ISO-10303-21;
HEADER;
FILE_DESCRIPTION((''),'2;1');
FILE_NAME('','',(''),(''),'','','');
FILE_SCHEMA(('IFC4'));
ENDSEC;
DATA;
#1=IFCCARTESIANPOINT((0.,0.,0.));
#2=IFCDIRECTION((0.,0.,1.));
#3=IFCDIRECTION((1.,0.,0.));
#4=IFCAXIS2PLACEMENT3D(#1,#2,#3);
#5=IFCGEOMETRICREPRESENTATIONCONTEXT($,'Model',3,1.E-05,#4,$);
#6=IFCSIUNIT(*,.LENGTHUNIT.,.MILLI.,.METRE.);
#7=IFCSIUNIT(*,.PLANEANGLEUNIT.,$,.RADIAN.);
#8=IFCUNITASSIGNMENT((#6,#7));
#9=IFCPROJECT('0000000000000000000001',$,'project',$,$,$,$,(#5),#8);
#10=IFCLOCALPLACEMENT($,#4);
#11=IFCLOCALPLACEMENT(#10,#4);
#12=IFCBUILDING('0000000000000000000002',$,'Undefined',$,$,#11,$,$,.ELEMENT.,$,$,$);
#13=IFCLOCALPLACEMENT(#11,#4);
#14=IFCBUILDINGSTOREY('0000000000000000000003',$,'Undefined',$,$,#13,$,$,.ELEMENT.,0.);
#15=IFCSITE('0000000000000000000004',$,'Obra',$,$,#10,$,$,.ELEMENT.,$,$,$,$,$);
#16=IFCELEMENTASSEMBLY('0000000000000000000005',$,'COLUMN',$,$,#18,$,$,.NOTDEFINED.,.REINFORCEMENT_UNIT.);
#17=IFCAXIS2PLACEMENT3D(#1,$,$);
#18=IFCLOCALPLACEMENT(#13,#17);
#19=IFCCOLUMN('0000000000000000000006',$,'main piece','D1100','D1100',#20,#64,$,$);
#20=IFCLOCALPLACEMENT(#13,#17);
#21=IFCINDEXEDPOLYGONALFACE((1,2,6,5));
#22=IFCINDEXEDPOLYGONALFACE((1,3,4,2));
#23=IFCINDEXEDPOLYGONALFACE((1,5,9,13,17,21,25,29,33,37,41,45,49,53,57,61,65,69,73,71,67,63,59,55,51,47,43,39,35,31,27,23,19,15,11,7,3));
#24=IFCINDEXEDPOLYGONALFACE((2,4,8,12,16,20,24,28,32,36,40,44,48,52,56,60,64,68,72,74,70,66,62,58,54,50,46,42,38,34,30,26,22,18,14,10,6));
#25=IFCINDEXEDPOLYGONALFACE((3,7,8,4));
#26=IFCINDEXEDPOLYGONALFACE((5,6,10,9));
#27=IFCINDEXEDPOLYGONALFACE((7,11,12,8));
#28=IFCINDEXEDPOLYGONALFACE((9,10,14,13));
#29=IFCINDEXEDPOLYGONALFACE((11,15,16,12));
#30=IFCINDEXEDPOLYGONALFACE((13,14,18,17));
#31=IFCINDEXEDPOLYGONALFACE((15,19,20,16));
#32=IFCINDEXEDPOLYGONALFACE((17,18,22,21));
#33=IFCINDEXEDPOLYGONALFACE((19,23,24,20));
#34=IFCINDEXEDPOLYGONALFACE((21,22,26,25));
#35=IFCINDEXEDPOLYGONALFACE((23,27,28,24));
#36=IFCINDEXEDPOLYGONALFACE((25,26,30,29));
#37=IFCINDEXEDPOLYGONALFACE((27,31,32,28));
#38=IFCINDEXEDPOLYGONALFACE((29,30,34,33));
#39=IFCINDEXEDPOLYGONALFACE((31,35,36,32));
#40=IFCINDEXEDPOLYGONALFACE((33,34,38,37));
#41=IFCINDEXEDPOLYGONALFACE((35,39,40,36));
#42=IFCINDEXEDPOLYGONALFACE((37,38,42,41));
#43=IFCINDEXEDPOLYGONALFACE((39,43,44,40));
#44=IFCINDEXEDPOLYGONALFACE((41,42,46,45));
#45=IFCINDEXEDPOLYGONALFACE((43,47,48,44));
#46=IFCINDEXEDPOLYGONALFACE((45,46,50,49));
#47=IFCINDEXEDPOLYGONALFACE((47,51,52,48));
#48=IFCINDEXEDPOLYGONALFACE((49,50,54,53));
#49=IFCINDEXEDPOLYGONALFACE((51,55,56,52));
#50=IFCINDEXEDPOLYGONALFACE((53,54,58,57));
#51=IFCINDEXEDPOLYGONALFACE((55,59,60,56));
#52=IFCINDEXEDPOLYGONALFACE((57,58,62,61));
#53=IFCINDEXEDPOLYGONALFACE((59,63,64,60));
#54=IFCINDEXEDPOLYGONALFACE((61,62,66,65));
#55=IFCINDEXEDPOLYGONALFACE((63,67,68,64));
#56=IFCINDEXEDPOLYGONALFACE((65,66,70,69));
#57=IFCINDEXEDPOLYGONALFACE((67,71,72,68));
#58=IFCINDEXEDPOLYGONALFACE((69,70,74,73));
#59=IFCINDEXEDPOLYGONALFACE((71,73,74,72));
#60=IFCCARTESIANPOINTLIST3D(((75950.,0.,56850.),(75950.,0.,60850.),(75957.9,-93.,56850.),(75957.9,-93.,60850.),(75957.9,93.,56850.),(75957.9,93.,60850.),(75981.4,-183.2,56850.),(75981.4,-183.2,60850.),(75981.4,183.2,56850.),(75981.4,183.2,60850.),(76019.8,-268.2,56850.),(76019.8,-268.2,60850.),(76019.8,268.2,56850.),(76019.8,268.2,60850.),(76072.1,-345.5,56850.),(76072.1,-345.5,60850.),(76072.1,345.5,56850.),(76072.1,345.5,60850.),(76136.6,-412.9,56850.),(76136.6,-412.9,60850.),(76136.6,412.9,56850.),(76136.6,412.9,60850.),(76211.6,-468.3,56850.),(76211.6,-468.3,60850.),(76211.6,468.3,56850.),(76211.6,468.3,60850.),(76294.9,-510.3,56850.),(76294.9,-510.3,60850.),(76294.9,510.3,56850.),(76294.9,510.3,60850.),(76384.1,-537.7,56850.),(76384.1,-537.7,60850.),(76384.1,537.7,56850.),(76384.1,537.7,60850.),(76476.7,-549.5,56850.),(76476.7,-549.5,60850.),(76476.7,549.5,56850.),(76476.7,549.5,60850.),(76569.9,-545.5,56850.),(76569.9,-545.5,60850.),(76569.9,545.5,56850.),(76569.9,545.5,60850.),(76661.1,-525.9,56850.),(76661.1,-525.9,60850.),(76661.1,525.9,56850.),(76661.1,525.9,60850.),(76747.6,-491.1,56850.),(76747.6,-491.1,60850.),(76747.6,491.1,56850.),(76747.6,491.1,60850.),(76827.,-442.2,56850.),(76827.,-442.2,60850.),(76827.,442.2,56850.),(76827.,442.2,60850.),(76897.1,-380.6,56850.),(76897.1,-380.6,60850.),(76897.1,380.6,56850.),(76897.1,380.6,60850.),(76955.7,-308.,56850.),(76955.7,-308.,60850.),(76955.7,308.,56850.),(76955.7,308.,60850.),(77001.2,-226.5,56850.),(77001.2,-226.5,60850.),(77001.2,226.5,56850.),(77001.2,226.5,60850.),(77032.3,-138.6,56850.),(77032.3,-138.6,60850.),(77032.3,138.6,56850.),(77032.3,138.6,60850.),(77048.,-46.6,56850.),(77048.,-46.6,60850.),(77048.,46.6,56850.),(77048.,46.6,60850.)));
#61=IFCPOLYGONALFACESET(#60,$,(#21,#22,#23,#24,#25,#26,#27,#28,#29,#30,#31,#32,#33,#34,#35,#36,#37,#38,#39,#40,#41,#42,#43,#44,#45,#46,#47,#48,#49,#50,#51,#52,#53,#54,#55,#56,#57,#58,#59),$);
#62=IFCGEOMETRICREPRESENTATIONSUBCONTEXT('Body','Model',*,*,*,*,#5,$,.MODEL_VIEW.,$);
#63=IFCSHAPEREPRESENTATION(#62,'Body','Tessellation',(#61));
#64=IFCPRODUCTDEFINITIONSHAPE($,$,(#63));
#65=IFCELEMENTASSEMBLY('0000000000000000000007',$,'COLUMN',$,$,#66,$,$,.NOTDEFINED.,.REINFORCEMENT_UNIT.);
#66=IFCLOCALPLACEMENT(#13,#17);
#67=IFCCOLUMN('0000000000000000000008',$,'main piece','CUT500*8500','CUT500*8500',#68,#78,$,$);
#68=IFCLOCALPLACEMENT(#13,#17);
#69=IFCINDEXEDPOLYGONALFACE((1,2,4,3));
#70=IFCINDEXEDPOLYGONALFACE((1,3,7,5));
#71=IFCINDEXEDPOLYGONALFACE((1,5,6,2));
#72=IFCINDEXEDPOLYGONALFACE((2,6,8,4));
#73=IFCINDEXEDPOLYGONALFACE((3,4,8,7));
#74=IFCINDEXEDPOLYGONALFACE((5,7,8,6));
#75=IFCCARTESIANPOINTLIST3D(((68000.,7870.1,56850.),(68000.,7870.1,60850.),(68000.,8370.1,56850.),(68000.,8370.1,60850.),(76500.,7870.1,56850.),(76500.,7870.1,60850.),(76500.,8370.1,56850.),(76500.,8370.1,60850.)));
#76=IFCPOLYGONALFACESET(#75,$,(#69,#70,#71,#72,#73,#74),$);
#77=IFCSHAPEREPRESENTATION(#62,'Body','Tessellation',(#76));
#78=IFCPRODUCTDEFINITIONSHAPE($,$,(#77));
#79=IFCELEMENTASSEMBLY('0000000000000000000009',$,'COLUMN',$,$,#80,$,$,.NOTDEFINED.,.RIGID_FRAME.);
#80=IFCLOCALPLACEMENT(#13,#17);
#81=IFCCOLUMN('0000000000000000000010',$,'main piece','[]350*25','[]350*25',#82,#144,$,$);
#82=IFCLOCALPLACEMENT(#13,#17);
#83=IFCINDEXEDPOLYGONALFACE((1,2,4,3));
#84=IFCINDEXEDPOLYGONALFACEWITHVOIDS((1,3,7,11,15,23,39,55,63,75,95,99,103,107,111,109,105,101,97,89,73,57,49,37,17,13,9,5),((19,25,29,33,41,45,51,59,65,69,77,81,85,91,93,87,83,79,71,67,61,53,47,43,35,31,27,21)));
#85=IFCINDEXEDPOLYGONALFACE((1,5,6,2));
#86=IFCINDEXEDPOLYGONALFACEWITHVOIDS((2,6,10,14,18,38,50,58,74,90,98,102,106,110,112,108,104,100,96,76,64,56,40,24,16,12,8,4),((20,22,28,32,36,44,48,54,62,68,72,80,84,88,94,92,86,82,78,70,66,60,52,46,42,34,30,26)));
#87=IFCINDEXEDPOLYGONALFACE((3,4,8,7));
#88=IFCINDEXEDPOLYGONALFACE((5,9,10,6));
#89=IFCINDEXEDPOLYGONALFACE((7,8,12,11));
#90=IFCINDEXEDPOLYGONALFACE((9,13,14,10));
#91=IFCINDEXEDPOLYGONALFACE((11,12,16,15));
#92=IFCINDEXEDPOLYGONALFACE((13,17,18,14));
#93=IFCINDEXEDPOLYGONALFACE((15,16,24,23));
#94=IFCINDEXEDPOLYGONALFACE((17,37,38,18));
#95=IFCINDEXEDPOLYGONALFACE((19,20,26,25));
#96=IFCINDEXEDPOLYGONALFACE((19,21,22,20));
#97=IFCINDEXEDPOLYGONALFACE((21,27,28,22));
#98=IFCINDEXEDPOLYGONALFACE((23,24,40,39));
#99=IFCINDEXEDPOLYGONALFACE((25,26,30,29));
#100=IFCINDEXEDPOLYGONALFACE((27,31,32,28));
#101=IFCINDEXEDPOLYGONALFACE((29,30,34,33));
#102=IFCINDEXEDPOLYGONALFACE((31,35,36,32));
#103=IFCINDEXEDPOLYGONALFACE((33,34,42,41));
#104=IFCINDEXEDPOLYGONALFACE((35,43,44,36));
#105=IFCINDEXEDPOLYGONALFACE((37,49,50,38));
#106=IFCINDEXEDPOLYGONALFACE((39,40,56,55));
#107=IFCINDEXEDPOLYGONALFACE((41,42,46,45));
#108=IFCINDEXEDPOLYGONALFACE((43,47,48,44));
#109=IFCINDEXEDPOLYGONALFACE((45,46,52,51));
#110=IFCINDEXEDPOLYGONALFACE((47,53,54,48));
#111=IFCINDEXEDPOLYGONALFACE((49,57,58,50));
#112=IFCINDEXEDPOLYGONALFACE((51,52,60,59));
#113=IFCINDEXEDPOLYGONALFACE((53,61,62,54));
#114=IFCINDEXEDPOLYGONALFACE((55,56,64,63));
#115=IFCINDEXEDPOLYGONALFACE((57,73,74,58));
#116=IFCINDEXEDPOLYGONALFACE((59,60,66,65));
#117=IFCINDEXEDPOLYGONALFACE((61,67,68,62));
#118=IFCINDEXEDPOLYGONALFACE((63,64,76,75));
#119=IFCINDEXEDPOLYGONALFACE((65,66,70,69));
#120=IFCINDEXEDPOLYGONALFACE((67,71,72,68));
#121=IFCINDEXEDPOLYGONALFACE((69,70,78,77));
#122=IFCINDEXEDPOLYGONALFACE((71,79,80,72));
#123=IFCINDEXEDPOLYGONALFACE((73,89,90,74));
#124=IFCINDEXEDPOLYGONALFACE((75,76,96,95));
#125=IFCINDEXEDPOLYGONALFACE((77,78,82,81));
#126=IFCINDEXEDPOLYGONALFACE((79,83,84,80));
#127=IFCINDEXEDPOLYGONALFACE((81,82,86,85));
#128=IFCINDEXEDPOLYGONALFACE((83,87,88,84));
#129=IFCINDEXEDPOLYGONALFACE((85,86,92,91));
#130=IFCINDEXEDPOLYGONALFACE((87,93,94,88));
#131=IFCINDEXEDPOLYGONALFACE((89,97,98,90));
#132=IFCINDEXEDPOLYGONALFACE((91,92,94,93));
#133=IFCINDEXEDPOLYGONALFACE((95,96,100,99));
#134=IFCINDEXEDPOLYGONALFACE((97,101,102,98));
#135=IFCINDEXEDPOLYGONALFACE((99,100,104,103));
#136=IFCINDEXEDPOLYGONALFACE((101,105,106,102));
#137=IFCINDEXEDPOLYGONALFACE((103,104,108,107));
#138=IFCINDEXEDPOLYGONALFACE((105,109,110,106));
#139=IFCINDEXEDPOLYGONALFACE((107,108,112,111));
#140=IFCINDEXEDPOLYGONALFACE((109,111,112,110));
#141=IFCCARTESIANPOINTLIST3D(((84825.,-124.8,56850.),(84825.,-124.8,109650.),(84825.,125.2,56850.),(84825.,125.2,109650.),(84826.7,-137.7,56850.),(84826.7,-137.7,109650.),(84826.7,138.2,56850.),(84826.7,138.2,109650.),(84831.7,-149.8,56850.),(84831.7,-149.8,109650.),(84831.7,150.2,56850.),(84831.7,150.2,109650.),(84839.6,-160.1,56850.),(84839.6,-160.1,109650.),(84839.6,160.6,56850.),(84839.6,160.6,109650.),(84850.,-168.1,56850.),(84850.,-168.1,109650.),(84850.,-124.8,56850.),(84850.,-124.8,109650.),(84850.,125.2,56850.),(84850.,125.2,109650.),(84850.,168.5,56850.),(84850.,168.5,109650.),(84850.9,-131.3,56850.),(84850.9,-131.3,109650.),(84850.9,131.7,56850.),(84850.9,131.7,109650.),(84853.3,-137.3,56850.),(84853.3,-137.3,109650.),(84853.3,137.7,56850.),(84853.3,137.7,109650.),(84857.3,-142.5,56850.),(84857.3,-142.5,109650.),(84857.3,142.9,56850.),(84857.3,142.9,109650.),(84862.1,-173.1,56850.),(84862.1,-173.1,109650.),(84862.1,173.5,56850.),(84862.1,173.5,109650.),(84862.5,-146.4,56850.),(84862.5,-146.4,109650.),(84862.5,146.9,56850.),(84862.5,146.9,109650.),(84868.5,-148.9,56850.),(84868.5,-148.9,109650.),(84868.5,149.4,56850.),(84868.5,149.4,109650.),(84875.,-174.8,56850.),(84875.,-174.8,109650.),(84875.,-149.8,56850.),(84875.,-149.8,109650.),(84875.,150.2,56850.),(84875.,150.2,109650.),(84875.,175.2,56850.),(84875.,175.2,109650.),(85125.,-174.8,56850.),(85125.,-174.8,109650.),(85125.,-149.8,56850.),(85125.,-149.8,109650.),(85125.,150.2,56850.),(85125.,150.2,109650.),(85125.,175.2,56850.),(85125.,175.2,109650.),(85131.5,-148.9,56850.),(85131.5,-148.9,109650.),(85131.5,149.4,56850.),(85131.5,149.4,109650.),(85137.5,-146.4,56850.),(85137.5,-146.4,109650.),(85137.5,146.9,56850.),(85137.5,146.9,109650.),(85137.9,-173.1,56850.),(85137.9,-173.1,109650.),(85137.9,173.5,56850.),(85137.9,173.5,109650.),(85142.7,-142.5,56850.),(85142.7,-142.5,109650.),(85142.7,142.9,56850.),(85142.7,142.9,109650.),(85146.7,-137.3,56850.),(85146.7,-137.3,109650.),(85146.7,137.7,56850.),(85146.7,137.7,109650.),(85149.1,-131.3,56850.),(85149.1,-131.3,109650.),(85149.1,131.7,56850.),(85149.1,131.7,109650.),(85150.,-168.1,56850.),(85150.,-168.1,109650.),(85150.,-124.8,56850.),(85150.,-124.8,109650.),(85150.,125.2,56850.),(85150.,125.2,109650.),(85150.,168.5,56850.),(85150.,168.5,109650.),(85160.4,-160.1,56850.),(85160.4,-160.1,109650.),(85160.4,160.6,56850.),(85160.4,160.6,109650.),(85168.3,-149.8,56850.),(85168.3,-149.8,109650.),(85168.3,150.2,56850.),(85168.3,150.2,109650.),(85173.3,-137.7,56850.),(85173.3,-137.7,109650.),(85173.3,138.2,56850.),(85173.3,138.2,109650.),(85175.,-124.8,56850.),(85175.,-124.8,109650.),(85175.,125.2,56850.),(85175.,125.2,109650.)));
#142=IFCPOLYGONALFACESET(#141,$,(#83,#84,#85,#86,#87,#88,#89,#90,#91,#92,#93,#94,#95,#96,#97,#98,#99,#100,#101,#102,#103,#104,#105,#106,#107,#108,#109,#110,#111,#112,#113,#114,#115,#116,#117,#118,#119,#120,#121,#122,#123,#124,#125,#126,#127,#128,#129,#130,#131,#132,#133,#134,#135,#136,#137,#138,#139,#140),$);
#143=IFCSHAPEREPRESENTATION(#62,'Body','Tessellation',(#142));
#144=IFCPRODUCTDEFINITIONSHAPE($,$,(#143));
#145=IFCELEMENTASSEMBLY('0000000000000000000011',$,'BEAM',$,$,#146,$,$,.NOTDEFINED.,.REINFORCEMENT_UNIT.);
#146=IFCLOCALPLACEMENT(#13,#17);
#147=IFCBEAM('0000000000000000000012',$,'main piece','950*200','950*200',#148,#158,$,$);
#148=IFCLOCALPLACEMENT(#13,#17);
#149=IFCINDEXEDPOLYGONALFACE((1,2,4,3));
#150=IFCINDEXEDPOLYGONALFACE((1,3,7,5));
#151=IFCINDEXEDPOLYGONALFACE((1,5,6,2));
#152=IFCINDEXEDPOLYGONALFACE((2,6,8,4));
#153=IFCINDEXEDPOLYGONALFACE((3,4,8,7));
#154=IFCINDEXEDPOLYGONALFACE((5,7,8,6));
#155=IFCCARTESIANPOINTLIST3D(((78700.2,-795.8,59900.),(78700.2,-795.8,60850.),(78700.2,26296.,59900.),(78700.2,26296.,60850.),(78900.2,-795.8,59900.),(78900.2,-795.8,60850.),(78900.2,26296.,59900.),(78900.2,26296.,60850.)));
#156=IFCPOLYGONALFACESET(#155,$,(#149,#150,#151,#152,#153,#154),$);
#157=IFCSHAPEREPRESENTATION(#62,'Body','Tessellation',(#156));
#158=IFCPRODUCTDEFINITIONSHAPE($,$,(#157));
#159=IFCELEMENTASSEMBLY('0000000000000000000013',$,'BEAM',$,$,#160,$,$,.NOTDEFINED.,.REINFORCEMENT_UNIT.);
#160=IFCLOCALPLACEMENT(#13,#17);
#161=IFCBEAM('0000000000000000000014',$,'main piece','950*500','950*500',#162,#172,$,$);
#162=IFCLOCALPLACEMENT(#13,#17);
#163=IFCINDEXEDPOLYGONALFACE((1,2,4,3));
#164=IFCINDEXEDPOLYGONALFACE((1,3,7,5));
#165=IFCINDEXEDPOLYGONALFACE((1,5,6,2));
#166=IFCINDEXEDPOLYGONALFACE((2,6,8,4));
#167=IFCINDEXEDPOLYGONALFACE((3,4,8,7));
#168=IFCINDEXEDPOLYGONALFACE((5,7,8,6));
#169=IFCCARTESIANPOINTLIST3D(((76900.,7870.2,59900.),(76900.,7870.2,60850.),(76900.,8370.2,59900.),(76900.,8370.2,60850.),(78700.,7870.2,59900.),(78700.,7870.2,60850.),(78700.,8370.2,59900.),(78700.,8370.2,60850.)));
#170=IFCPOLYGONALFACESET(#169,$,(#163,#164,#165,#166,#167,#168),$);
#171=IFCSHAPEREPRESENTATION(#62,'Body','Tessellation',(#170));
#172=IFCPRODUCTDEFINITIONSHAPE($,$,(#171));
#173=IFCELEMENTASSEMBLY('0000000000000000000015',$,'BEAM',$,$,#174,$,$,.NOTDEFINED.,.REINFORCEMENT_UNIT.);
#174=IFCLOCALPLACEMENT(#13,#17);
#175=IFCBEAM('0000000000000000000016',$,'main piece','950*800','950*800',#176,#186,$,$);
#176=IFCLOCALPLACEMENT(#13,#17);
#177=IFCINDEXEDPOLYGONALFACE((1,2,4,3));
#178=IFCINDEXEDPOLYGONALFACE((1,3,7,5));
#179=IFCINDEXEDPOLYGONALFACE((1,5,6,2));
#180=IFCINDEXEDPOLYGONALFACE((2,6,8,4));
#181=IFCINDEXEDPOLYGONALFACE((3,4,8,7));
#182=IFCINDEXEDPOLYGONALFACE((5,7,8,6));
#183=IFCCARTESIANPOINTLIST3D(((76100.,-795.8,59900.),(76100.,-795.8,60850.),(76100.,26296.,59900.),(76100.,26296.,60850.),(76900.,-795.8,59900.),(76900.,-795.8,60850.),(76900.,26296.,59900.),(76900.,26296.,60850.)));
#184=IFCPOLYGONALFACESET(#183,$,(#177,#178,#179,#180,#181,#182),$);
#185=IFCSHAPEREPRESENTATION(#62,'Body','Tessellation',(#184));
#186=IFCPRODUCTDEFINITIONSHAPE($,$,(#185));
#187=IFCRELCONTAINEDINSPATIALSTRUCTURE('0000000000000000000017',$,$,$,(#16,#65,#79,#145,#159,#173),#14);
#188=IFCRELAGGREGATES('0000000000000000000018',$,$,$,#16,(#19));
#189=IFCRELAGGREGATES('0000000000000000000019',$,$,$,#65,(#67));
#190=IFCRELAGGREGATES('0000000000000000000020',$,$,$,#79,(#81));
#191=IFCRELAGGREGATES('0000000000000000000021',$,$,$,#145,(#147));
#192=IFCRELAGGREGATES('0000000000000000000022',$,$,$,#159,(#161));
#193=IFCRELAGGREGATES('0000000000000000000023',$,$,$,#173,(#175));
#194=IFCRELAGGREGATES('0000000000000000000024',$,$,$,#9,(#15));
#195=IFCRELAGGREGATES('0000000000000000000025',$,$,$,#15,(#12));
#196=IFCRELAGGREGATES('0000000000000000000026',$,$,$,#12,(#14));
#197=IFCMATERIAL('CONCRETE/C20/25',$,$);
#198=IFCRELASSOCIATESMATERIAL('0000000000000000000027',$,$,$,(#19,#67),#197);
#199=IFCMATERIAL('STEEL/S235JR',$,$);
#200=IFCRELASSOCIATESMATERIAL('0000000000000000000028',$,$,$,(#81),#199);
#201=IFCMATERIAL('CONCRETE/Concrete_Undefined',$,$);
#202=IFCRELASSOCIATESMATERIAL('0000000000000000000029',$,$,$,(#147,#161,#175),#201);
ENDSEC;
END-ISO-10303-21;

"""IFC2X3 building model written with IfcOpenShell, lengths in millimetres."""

from ifc_helpers import new_model, si_unit, frame, origin_with_axes, origin_2d_with_axis, place, context, subcontext, project, spatial, rectangle, hollow_rectangle, circle, extrude, material, element, aggregate, save


model = new_model("IFC2X3")

# Units and contexts
model_context = context("Model", 3, precision=1e-05, world=origin_with_axes())
body_context = subcontext(model_context, "Body", "Model", "MODEL_VIEW")
ifc_project = project(units=[si_unit("LENGTHUNIT", "METRE", prefix="MILLI"), si_unit("PLANEANGLEUNIT", "RADIAN")], contexts=[model_context])

# Site, building, storey
site_placement = place(None, origin_with_axes())
site = spatial("IfcSite", under=ifc_project, at=site_placement, Name="Obra", CompositionType="ELEMENT")
building_placement = place(site_placement, origin_with_axes())
building = spatial("IfcBuilding", under=site, at=building_placement, Name="Undefined", CompositionType="ELEMENT")
storey_placement = place(building_placement, origin_with_axes())
storey = spatial("IfcBuildingStorey", under=building, at=storey_placement, Name="Undefined", CompositionType="ELEMENT", Elevation=0.0)

# Element assemblies, columns
assembly_1_placement = place(storey_placement, origin_with_axes())
assembly_1 = element("IfcElementAssembly", 1, at=assembly_1_placement, inside=storey, Name="COLUMN", AssemblyPlace="NOTDEFINED", PredefinedType="REINFORCEMENT_UNIT")
ifc_material_1 = material(Name="CONCRETE/C20/25")
column_1_placement = place(assembly_1_placement, frame((76500.0, 0.0, 56850.0), z_axis=(0.0, 0.0, 1.0), x_axis=(0.0, 1.0, 0.0)))
column_1 = element("IfcColumn", 2, at=column_1_placement, material=ifc_material_1, Name="main piece", Description="D1100", ObjectType="D1100", context=body_context, shape_type="SweptSolid", body=[
    extrude(circle(Radius=550.0, at=origin_2d_with_axis()), frame((0.0, 0.0, 4000.0), z_axis=(0.0, 0.0, -1.0), x_axis=(0.0, 1.0, 0.0)), (0.0, 0.0, 1.0), 4000.0),
])
aggregate(assembly_1, [column_1])
assembly_2_placement = place(storey_placement, origin_with_axes())
assembly_2 = element("IfcElementAssembly", 3, at=assembly_2_placement, inside=storey, Name="COLUMN", AssemblyPlace="NOTDEFINED", PredefinedType="REINFORCEMENT_UNIT")
column_2_placement = place(assembly_2_placement, frame((72250.0, 8120.1, 56850.0), z_axis=(0.0, 0.0, 1.0), x_axis=(-1.0, 0.0, 0.0)))
column_2 = element("IfcColumn", 4, at=column_2_placement, material=ifc_material_1, Name="main piece", Description="CUT500*8500", ObjectType="CUT500*8500", context=body_context, shape_type="SweptSolid", body=[
    extrude(rectangle(XDim=500.0, YDim=8500.0, at=origin_2d_with_axis()), frame((0.0, 0.0, 4000.0), z_axis=(0.0, 0.0, -1.0), x_axis=(0.0, 1.0, 0.0)), (0.0, 0.0, 1.0), 4000.0),
])
aggregate(assembly_2, [column_2])
assembly_3_placement = place(storey_placement, origin_with_axes())
assembly_3 = element("IfcElementAssembly", 5, at=assembly_3_placement, inside=storey, Name="COLUMN", AssemblyPlace="NOTDEFINED", PredefinedType="RIGID_FRAME")
ifc_material_2 = material(Name="STEEL/S235JR")
column_3_placement = place(assembly_3_placement, frame((85000.0, 0.2, 56850.0), z_axis=(0.0, 0.0, 1.0), x_axis=(0.0, 1.0, 0.0)))
column_3 = element("IfcColumn", 6, at=column_3_placement, material=ifc_material_2, Name="main piece", Description="[]350*25", ObjectType="[]350*25", context=body_context, shape_type="SweptSolid", body=[
    extrude(hollow_rectangle(XDim=350.0, YDim=350.0, WallThickness=25.0, InnerFilletRadius=25.0, OuterFilletRadius=50.0, at=origin_2d_with_axis()), frame((0.0, 0.0, 52800.0), z_axis=(0.0, 0.0, -1.0), x_axis=(0.0, 1.0, 0.0)), (0.0, 0.0, 1.0), 52800.0),
])
aggregate(assembly_3, [column_3])

# Element assemblies, beams
assembly_4_placement = place(storey_placement, origin_with_axes())
assembly_4 = element("IfcElementAssembly", 7, at=assembly_4_placement, inside=storey, Name="BEAM", AssemblyPlace="NOTDEFINED", PredefinedType="REINFORCEMENT_UNIT")
ifc_material_3 = material(Name="CONCRETE/Concrete_Undefined")
beam_1_placement = place(assembly_4_placement, frame((78800.2, -795.8, 60375.0), z_axis=(0.0, 0.0, 1.0), x_axis=(0.0, 1.0, 0.0)))
beam_1 = element("IfcBeam", 8, at=beam_1_placement, material=ifc_material_3, Name="main piece", Description="950*200", ObjectType="950*200", context=body_context, shape_type="SweptSolid", body=[
    extrude(rectangle(XDim=200.0, YDim=950.0, at=origin_2d_with_axis()), frame((27091.8, 0.0, 0.0), z_axis=(-1.0, 0.0, 0.0), x_axis=(0.0, -1.0, 0.0)), (0.0, 0.0, 1.0), 27091.8),
])
aggregate(assembly_4, [beam_1])
assembly_5_placement = place(storey_placement, origin_with_axes())
assembly_5 = element("IfcElementAssembly", 9, at=assembly_5_placement, inside=storey, Name="BEAM", AssemblyPlace="NOTDEFINED", PredefinedType="REINFORCEMENT_UNIT")
beam_2_placement = place(assembly_5_placement, frame((78700.0, 8120.2, 60375.0), z_axis=(0.0, 0.0, 1.0), x_axis=(-1.0, 0.0, 0.0)))
beam_2 = element("IfcBeam", 10, at=beam_2_placement, material=ifc_material_3, Name="main piece", Description="950*500", ObjectType="950*500", context=body_context, shape_type="SweptSolid", body=[
    extrude(rectangle(XDim=500.0, YDim=950.0, at=origin_2d_with_axis()), frame((1800.0, 0.0, 0.0), z_axis=(-1.0, 0.0, 0.0), x_axis=(0.0, -1.0, 0.0)), (0.0, 0.0, 1.0), 1800.0),
])
aggregate(assembly_5, [beam_2])
assembly_6_placement = place(storey_placement, origin_with_axes())
assembly_6 = element("IfcElementAssembly", 11, at=assembly_6_placement, inside=storey, Name="BEAM", AssemblyPlace="NOTDEFINED", PredefinedType="REINFORCEMENT_UNIT")
beam_3_placement = place(assembly_6_placement, frame((76500.0, -795.8, 60375.0), z_axis=(0.0, 0.0, 1.0), x_axis=(0.0, 1.0, 0.0)))
beam_3 = element("IfcBeam", 12, at=beam_3_placement, material=ifc_material_3, Name="main piece", Description="950*800", ObjectType="950*800", context=body_context, shape_type="SweptSolid", body=[
    extrude(rectangle(XDim=800.0, YDim=950.0, at=origin_2d_with_axis()), frame((27091.8, 0.0, 0.0), z_axis=(-1.0, 0.0, 0.0), x_axis=(0.0, -1.0, 0.0)), (0.0, 0.0, 1.0), 27091.8),
])
aggregate(assembly_6, [beam_3])

save(model, "model.ifc")
